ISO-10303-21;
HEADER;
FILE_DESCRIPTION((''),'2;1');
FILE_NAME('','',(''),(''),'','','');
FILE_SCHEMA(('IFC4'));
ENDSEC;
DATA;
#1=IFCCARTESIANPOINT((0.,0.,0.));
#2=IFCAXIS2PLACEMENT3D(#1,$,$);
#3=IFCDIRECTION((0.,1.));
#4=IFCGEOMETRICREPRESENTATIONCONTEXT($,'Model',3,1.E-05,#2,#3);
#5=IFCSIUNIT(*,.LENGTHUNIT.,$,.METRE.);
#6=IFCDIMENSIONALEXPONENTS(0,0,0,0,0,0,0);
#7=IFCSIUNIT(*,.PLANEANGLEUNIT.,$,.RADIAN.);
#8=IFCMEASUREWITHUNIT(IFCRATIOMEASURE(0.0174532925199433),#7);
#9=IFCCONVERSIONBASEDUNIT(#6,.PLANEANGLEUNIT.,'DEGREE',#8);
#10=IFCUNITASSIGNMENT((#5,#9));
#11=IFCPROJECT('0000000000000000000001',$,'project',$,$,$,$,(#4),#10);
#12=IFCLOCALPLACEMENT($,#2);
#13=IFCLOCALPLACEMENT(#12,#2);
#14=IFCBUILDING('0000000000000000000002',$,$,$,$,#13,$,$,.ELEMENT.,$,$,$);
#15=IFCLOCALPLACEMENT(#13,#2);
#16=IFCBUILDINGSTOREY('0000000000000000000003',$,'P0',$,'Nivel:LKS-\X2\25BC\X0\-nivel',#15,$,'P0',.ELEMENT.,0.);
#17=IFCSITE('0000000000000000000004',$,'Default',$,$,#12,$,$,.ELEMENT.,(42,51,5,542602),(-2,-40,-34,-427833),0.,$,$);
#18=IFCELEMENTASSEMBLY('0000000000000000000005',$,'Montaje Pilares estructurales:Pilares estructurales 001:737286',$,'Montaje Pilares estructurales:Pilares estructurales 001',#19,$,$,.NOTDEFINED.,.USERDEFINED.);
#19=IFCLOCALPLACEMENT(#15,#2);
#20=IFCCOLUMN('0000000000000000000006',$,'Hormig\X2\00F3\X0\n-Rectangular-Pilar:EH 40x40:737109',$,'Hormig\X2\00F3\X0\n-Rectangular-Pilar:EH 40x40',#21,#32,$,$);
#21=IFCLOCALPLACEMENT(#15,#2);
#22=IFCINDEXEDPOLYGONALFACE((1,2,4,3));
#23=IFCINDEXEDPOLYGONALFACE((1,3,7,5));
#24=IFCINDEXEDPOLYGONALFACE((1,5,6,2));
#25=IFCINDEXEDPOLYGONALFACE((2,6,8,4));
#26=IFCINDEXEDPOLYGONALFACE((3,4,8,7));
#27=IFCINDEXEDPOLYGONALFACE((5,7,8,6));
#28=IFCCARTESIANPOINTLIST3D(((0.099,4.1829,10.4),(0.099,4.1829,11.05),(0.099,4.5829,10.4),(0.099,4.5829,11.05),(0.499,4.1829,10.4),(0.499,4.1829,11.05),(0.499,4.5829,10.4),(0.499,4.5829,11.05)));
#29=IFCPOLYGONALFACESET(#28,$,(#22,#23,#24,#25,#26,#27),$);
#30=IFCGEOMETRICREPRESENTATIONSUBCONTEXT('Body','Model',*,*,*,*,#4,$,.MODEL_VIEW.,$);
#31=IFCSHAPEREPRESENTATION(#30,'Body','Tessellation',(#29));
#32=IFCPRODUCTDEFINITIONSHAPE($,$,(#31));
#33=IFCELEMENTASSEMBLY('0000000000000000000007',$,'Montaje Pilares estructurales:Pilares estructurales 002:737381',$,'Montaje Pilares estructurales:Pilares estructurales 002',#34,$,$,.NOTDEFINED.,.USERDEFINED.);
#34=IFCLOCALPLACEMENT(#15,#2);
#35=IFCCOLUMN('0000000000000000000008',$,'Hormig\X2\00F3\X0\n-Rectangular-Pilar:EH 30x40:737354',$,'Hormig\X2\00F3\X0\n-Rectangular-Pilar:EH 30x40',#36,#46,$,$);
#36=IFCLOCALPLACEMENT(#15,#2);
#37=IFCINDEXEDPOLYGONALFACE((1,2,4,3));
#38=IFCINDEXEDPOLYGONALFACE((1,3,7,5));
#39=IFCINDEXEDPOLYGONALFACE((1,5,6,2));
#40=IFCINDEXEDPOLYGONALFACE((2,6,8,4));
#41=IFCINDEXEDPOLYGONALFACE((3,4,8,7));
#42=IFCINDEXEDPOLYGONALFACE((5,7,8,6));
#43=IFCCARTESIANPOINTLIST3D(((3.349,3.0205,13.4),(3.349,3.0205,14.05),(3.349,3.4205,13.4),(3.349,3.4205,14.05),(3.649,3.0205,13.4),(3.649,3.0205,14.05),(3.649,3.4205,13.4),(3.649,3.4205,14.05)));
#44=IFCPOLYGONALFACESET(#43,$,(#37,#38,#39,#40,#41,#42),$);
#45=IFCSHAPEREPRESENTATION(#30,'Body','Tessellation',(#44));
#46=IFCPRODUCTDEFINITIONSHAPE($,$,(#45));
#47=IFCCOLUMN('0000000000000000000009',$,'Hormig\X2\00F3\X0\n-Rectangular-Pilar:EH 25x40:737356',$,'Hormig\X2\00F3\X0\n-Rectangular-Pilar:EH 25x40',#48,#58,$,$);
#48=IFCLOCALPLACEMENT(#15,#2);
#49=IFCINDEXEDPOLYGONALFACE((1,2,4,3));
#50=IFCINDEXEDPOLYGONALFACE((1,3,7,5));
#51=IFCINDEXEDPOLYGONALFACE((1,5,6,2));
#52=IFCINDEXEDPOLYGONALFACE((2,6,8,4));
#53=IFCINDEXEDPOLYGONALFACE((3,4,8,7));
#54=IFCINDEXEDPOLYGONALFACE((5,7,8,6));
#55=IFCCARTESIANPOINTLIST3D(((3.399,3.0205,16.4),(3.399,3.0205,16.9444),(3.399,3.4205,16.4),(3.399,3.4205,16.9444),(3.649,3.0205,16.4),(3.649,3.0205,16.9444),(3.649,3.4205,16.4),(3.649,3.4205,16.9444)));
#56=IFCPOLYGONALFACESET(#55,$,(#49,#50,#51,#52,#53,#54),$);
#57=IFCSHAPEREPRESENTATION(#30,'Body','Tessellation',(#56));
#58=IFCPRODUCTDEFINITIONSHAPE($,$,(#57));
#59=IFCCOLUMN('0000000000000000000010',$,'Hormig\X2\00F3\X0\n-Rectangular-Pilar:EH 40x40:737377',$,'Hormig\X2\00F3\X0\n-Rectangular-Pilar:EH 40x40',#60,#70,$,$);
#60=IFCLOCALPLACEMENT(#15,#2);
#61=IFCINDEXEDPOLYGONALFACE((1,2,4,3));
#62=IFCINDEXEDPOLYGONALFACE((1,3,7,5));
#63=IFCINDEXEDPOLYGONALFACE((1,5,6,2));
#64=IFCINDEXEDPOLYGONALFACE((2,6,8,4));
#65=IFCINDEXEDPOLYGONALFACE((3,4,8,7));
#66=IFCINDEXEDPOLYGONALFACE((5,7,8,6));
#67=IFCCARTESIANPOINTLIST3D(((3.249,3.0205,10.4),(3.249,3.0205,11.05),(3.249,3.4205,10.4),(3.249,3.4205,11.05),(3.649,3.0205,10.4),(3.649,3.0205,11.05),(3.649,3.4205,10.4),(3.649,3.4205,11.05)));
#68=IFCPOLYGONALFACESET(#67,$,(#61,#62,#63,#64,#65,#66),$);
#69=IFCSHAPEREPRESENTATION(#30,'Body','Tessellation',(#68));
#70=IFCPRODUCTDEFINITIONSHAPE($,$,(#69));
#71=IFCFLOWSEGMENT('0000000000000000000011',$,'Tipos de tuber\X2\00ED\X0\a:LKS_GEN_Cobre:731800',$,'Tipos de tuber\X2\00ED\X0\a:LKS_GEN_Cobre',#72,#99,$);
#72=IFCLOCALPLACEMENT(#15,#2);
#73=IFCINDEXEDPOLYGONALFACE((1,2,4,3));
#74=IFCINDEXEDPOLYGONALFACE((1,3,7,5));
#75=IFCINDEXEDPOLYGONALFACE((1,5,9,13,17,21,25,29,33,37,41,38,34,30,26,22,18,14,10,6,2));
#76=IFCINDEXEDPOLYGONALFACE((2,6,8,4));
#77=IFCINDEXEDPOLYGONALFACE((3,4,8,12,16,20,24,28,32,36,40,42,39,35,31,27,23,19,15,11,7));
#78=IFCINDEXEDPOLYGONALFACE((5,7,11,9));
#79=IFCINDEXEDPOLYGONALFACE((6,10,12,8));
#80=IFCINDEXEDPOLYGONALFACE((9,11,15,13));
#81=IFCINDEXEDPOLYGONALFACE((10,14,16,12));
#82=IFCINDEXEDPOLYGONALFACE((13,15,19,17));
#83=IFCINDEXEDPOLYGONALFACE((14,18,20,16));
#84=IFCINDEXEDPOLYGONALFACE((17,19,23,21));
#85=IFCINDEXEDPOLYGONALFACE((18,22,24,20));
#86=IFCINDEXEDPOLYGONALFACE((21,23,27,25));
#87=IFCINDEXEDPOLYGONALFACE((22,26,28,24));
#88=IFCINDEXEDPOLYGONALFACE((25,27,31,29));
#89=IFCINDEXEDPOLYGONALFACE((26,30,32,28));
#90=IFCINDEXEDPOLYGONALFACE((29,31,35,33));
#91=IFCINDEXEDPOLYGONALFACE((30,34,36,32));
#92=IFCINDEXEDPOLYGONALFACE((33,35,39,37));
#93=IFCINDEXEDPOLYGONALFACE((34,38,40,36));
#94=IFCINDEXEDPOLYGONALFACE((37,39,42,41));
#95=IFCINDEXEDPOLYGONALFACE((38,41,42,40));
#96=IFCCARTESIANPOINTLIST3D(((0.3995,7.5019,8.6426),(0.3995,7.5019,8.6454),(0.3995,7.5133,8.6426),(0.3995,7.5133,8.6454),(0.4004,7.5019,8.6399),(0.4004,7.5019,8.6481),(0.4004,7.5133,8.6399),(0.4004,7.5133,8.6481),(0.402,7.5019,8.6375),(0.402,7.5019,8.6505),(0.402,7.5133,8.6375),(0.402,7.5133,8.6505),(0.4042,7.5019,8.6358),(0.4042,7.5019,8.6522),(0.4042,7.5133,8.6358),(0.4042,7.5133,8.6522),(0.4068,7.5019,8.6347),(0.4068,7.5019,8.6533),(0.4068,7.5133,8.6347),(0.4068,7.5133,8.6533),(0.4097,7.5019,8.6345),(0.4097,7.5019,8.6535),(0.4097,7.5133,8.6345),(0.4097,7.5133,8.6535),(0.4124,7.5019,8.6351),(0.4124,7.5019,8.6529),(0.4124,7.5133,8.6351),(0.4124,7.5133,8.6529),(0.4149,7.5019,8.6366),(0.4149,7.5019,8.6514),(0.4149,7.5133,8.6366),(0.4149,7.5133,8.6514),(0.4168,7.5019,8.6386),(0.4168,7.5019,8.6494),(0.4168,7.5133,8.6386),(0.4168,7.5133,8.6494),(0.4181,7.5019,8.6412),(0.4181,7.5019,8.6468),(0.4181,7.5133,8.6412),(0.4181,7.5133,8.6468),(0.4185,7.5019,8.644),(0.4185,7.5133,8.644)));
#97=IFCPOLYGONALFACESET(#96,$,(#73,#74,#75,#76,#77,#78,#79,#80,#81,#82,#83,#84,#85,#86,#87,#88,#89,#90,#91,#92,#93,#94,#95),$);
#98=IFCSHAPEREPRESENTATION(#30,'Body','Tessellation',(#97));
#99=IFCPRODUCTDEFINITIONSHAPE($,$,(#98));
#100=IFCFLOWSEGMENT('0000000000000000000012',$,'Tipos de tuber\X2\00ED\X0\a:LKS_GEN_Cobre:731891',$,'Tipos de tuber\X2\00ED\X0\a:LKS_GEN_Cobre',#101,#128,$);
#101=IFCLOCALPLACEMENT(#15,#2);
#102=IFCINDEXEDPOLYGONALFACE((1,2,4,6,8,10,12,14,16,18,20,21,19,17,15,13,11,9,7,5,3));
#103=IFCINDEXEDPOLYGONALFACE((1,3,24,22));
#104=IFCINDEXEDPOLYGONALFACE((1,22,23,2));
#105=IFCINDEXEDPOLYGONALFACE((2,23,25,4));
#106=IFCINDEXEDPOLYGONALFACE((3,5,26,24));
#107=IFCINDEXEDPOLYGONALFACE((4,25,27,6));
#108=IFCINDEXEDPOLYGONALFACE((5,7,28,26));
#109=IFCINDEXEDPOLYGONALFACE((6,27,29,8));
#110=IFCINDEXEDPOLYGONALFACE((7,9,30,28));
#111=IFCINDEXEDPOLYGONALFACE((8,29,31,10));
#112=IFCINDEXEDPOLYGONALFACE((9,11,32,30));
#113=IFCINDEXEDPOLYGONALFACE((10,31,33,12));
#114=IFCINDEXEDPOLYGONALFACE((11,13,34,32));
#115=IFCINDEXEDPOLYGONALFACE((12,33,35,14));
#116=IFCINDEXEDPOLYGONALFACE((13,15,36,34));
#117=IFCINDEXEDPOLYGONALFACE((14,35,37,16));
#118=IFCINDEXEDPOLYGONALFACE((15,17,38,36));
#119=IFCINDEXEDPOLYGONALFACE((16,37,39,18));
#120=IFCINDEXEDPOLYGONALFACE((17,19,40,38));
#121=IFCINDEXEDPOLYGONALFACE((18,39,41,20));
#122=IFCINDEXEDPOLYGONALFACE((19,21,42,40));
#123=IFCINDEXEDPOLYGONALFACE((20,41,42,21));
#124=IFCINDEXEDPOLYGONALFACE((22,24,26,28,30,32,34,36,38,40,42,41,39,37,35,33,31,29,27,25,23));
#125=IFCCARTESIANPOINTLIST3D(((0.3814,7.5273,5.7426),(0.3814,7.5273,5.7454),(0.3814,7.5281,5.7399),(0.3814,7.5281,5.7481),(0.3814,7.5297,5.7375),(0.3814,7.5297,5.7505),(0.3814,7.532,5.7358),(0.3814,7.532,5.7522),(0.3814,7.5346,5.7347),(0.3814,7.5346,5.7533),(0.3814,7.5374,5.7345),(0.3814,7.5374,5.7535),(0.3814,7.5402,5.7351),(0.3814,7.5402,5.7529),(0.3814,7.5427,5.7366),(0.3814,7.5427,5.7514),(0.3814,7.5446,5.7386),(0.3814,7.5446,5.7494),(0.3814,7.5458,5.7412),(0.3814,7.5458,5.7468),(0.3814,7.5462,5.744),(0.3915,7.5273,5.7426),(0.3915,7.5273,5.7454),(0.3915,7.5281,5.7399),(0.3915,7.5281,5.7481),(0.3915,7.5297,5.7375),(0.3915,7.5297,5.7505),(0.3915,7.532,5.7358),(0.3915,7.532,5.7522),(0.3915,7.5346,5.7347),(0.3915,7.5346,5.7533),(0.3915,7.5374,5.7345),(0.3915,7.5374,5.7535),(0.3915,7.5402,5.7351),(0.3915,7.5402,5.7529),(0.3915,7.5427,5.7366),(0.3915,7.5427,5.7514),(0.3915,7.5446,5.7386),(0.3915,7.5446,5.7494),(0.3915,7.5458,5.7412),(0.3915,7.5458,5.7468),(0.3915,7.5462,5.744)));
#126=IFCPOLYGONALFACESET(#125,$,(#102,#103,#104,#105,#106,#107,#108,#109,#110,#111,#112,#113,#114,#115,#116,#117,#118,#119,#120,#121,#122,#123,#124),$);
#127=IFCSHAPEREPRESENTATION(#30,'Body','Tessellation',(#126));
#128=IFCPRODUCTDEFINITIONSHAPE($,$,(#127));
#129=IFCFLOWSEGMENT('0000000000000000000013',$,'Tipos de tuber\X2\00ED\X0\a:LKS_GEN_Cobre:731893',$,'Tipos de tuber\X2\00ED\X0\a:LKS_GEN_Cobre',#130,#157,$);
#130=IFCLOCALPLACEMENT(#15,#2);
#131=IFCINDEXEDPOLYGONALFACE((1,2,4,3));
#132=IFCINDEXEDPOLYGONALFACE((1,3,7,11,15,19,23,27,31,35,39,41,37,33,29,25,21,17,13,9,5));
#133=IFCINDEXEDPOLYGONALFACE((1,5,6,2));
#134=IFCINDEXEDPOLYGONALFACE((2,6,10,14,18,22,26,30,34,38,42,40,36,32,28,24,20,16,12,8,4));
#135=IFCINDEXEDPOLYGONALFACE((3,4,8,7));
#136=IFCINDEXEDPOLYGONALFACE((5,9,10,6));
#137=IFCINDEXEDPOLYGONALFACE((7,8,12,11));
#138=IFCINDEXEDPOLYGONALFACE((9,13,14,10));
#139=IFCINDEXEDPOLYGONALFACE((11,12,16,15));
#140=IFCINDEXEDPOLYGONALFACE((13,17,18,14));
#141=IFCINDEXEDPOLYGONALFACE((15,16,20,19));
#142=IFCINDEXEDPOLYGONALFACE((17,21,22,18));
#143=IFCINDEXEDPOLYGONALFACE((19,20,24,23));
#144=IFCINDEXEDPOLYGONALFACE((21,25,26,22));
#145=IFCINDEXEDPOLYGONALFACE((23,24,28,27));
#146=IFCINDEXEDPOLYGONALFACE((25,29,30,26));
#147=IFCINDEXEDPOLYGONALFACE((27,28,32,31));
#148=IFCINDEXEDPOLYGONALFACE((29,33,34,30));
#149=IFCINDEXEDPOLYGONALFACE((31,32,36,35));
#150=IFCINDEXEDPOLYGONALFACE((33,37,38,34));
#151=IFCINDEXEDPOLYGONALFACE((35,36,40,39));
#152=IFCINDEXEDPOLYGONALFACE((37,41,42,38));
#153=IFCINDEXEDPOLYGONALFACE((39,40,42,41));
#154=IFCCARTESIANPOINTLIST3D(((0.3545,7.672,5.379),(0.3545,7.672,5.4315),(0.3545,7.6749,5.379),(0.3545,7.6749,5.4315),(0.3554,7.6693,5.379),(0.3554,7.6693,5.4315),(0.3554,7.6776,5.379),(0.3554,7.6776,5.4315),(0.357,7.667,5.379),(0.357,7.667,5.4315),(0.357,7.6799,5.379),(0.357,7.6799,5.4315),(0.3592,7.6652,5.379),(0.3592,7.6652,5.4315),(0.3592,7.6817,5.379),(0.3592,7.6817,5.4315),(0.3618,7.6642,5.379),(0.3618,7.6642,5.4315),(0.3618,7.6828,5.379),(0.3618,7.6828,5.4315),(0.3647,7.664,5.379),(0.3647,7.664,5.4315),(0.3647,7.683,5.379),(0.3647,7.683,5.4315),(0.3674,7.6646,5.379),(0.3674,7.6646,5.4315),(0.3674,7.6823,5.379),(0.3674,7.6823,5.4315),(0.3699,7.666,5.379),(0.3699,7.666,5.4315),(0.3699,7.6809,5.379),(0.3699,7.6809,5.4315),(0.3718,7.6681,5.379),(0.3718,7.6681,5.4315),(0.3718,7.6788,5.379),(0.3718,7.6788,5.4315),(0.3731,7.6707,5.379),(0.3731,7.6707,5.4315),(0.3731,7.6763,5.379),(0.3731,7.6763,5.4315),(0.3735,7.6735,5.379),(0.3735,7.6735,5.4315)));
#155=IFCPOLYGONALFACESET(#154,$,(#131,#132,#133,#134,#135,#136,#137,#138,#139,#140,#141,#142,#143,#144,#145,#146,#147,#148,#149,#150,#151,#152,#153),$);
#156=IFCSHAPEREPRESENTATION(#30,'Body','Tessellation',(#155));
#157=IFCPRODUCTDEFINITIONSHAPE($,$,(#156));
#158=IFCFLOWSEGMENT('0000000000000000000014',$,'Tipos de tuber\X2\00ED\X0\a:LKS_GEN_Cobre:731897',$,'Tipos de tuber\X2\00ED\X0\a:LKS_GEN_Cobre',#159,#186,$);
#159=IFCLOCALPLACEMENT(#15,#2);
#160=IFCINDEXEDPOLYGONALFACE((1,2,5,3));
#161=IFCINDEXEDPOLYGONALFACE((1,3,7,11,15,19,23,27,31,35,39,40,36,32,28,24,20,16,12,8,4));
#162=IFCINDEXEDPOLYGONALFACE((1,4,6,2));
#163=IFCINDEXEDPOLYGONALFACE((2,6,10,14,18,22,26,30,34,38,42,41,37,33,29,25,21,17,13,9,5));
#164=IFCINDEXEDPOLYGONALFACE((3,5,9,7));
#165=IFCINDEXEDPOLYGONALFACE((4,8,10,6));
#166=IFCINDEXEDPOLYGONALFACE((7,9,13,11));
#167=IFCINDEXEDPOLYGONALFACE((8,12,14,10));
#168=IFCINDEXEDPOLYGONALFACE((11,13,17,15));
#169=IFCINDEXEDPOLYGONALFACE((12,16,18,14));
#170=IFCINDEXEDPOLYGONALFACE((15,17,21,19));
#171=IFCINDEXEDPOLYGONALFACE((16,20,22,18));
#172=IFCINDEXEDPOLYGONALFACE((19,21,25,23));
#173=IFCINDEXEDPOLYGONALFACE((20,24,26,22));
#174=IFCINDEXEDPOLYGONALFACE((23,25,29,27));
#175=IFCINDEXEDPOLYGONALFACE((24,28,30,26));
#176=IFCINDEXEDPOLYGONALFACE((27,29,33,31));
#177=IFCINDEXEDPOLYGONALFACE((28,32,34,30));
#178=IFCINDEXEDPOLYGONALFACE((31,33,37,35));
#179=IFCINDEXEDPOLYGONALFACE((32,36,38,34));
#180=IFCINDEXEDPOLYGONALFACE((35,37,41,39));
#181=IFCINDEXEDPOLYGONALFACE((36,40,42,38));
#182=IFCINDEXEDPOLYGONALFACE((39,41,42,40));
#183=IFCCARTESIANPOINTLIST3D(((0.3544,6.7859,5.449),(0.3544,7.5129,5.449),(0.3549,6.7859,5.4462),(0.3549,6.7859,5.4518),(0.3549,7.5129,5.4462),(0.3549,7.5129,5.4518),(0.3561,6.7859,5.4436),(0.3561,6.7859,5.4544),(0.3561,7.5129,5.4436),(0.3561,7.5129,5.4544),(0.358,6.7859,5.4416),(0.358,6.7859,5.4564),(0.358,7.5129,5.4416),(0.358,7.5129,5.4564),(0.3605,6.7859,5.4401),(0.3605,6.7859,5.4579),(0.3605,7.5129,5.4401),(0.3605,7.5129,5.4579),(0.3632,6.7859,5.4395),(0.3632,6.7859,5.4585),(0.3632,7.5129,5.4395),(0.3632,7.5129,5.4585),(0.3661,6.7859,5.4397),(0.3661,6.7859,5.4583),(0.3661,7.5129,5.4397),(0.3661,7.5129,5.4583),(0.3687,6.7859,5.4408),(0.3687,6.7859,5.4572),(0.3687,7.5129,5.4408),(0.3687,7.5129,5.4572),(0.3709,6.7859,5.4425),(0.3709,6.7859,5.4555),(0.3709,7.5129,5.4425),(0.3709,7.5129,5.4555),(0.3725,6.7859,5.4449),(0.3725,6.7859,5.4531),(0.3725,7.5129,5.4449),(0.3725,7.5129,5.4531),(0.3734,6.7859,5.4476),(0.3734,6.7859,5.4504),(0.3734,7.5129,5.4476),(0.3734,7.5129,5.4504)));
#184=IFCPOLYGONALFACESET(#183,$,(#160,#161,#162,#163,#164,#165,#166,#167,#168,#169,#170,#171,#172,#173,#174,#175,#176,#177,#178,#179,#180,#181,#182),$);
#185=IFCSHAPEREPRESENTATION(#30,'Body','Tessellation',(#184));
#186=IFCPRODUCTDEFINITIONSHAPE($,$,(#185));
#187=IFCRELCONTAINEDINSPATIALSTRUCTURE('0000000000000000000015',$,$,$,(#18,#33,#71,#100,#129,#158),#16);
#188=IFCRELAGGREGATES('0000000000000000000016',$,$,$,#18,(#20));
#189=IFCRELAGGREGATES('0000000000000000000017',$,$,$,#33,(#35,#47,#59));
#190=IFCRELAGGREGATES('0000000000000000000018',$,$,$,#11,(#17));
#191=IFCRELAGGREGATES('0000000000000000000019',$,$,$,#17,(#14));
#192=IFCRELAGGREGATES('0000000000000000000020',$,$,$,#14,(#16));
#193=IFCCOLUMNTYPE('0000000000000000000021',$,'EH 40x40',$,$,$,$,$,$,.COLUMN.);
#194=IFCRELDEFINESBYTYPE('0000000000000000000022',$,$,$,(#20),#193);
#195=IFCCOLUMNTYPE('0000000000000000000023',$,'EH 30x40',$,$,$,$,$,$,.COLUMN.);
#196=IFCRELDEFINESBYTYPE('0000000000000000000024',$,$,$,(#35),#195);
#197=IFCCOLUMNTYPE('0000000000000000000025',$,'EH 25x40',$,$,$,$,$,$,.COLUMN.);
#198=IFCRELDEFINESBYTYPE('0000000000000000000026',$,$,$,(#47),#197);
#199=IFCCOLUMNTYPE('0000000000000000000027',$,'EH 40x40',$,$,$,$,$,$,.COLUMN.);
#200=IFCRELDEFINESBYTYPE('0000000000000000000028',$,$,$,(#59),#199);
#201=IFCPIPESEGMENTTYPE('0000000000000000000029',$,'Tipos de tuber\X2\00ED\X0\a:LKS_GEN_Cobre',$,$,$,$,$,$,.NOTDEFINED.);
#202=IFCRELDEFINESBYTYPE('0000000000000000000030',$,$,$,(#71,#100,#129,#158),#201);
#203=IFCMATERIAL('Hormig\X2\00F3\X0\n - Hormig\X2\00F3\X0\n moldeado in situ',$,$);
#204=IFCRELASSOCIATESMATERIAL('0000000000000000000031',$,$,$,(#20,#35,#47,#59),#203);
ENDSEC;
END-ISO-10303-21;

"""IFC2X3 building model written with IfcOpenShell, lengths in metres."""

from ifc_helpers import new_model, entity, si_unit, converted_unit, direction, frame, frame_2d, origin, origin_2d_with_axis, place, context, subcontext, project, spatial, rectangle, circle, extrude, source, transform, mapped, material, type_object, type_shapes, element, aggregate, save


model = new_model("IFC2X3")

# Units and contexts
model_context = context("Model", 3, precision=1e-05, world=origin(), true_north=direction((0.0, 1.0)))
body_context = subcontext(model_context, "Body", "Model", "MODEL_VIEW")
ifc_project = project(units=[si_unit("LENGTHUNIT", "METRE"), converted_unit("PLANEANGLEUNIT", "DEGREE", entity("IfcRatioMeasure", 0.0174532925199433), si_unit("PLANEANGLEUNIT", "RADIAN"), dimensions=[0, 0, 0, 0, 0, 0, 0])], contexts=[model_context])

# Site, building, storey
site_placement = place(None, origin())
site = spatial("IfcSite", under=ifc_project, at=site_placement, Name="Default", CompositionType="ELEMENT", RefLatitude=(42, 51, 5, 542602), RefLongitude=(-2, -40, -34, -427833), RefElevation=0.0)
building_placement = place(site_placement, origin())
building = spatial("IfcBuilding", under=site, at=building_placement, CompositionType="ELEMENT")
storey_placement = place(building_placement, origin())
storey = spatial("IfcBuildingStorey", under=building, at=storey_placement, Name="P0", ObjectType="Nivel:LKS-▼-nivel", LongName="P0", CompositionType="ELEMENT", Elevation=0.0)

# Element assembly, column
assembly_1_placement = place(storey_placement, origin())
assembly_1 = element("IfcElementAssembly", 1, at=assembly_1_placement, inside=storey, Name="Montaje Pilares estructurales:Pilares estructurales 001:737286", ObjectType="Montaje Pilares estructurales:Pilares estructurales 001", AssemblyPlace="NOTDEFINED", PredefinedType="USERDEFINED")
ifc_material = material(Name="Hormigón - Hormigón moldeado in situ")
column_type_1 = type_object("IfcColumnType", Name="EH 40x40", PredefinedType="COLUMN")
shared_shape_1 = source(origin(), body_context, "Body", "SweptSolid", [
    extrude(rectangle(XDim=0.4, YDim=0.4, at=frame_2d((0.0, 0.0), x_axis=(1.0, 0.0))), frame((0.299, 4.3829, 10.4), z_axis=(0.0, 0.0, 1.0), x_axis=(0.0, -1.0, 0.0)), (0.0, 0.0, 1.0), 0.65),
])
type_shapes(column_type_1, [shared_shape_1])
column_1_placement = place(assembly_1_placement, origin())
column_1 = element("IfcColumn", 2, at=column_1_placement, type_object=column_type_1, material=ifc_material, Name="Hormigón-Rectangular-Pilar:EH 40x40:737109", ObjectType="Hormigón-Rectangular-Pilar:EH 40x40", context=body_context, shape_type="MappedRepresentation", body=[
    mapped(shared_shape_1, transform((0.0, 0.0, 0.0), scale=1.0)),
])
aggregate(assembly_1, [column_1])

# Element assembly, columns
assembly_2_placement = place(storey_placement, origin())
assembly_2 = element("IfcElementAssembly", 3, at=assembly_2_placement, inside=storey, Name="Montaje Pilares estructurales:Pilares estructurales 002:737381", ObjectType="Montaje Pilares estructurales:Pilares estructurales 002", AssemblyPlace="NOTDEFINED", PredefinedType="USERDEFINED")
column_type_2 = type_object("IfcColumnType", Name="EH 30x40", PredefinedType="COLUMN")
shared_shape_2 = source(origin(), body_context, "Body", "SweptSolid", [
    extrude(rectangle(XDim=0.4, YDim=0.3, at=frame_2d((0.0, 0.0), x_axis=(1.0, 0.0))), frame((3.499, 3.2205, 13.4), z_axis=(0.0, 0.0, 1.0), x_axis=(0.0, -1.0, 0.0)), (0.0, 0.0, 1.0), 0.65),
])
type_shapes(column_type_2, [shared_shape_2])
column_2_placement = place(assembly_2_placement, origin())
column_2 = element("IfcColumn", 4, at=column_2_placement, type_object=column_type_2, material=ifc_material, Name="Hormigón-Rectangular-Pilar:EH 30x40:737354", ObjectType="Hormigón-Rectangular-Pilar:EH 30x40", context=body_context, shape_type="MappedRepresentation", body=[
    mapped(shared_shape_2, transform((0.0, 0.0, 0.0), scale=1.0)),
])
column_type_3 = type_object("IfcColumnType", Name="EH 25x40", PredefinedType="COLUMN")
shared_shape_3 = source(origin(), body_context, "Body", "SweptSolid", [
    extrude(rectangle(XDim=0.4, YDim=0.25, at=frame_2d((0.0, 0.0), x_axis=(1.0, 0.0))), frame((3.524, 3.2205, 16.4), z_axis=(0.0, 0.0, 1.0), x_axis=(0.0, -1.0, 0.0)), (0.0, 0.0, 1.0), 0.5444),
])
type_shapes(column_type_3, [shared_shape_3])
column_3_placement = place(assembly_2_placement, origin())
column_3 = element("IfcColumn", 5, at=column_3_placement, type_object=column_type_3, material=ifc_material, Name="Hormigón-Rectangular-Pilar:EH 25x40:737356", ObjectType="Hormigón-Rectangular-Pilar:EH 25x40", context=body_context, shape_type="MappedRepresentation", body=[
    mapped(shared_shape_3, transform((0.0, 0.0, 0.0), scale=1.0)),
])
column_type_4 = type_object("IfcColumnType", Name="EH 40x40", PredefinedType="COLUMN")
shared_shape_4 = source(origin(), body_context, "Body", "SweptSolid", [
    extrude(rectangle(XDim=0.4, YDim=0.4, at=origin_2d_with_axis()), frame((3.449, 3.2205, 10.4), z_axis=(0.0, 0.0, 1.0), x_axis=(0.0, -1.0, 0.0)), (0.0, 0.0, 1.0), 0.65),
])
type_shapes(column_type_4, [shared_shape_4])
column_4_placement = place(assembly_2_placement, origin())
column_4 = element("IfcColumn", 6, at=column_4_placement, type_object=column_type_4, material=ifc_material, Name="Hormigón-Rectangular-Pilar:EH 40x40:737377", ObjectType="Hormigón-Rectangular-Pilar:EH 40x40", context=body_context, shape_type="MappedRepresentation", body=[
    mapped(shared_shape_4, transform((0.0, 0.0, 0.0), scale=1.0)),
])
aggregate(assembly_2, [column_2, column_3, column_4])

# Flow segments
pipe_segment_type = type_object("IfcPipeSegmentType", Name="Tipos de tubería:LKS_GEN_Cobre", PredefinedType="NOTDEFINED")
flow_segment_1_placement = place(storey_placement, origin())
element("IfcFlowSegment", 7, at=flow_segment_1_placement, inside=storey, type_object=pipe_segment_type, Name="Tipos de tubería:LKS_GEN_Cobre:731800", ObjectType="Tipos de tubería:LKS_GEN_Cobre", context=body_context, shape_type="SweptSolid", body=[
    extrude(circle(Radius=0.0095, at=origin_2d_with_axis()), frame((0.409, 7.5019, 8.644), z_axis=(0.0, 1.0, 0.0), x_axis=(1.0, 0.0, 0.0)), (0.0, 0.0, 1.0), 0.0114),
])
flow_segment_2_placement = place(storey_placement, origin())
element("IfcFlowSegment", 8, at=flow_segment_2_placement, inside=storey, type_object=pipe_segment_type, Name="Tipos de tubería:LKS_GEN_Cobre:731891", ObjectType="Tipos de tubería:LKS_GEN_Cobre", context=body_context, shape_type="SweptSolid", body=[
    extrude(circle(Radius=0.0095, at=frame_2d((0.0, 0.0), x_axis=(1.0, 0.0))), frame((0.3814, 7.5367, 5.744), z_axis=(1.0, 0.0, 0.0), x_axis=(0.0, 1.0, 0.0)), (0.0, 0.0, 1.0), 0.0101),
])
flow_segment_3_placement = place(storey_placement, origin())
element("IfcFlowSegment", 9, at=flow_segment_3_placement, inside=storey, type_object=pipe_segment_type, Name="Tipos de tubería:LKS_GEN_Cobre:731893", ObjectType="Tipos de tubería:LKS_GEN_Cobre", context=body_context, shape_type="SweptSolid", body=[
    extrude(circle(Radius=0.0095, at=frame_2d((0.0, 0.0), x_axis=(1.0, 0.0))), frame((0.364, 7.6735, 5.379)), (0.0, 0.0, 1.0), 0.0525),
])
flow_segment_4_placement = place(storey_placement, origin())
element("IfcFlowSegment", 10, at=flow_segment_4_placement, inside=storey, type_object=pipe_segment_type, Name="Tipos de tubería:LKS_GEN_Cobre:731897", ObjectType="Tipos de tubería:LKS_GEN_Cobre", context=body_context, shape_type="SweptSolid", body=[
    extrude(circle(Radius=0.0095, at=frame_2d((0.0, 0.0), x_axis=(1.0, 0.0))), frame((0.364, 6.7859, 5.449), z_axis=(0.0, 1.0, 0.0), x_axis=(-1.0, 0.0, 0.0)), (0.0, 0.0, 1.0), 0.727),
])

save(model, "model.ifc")
